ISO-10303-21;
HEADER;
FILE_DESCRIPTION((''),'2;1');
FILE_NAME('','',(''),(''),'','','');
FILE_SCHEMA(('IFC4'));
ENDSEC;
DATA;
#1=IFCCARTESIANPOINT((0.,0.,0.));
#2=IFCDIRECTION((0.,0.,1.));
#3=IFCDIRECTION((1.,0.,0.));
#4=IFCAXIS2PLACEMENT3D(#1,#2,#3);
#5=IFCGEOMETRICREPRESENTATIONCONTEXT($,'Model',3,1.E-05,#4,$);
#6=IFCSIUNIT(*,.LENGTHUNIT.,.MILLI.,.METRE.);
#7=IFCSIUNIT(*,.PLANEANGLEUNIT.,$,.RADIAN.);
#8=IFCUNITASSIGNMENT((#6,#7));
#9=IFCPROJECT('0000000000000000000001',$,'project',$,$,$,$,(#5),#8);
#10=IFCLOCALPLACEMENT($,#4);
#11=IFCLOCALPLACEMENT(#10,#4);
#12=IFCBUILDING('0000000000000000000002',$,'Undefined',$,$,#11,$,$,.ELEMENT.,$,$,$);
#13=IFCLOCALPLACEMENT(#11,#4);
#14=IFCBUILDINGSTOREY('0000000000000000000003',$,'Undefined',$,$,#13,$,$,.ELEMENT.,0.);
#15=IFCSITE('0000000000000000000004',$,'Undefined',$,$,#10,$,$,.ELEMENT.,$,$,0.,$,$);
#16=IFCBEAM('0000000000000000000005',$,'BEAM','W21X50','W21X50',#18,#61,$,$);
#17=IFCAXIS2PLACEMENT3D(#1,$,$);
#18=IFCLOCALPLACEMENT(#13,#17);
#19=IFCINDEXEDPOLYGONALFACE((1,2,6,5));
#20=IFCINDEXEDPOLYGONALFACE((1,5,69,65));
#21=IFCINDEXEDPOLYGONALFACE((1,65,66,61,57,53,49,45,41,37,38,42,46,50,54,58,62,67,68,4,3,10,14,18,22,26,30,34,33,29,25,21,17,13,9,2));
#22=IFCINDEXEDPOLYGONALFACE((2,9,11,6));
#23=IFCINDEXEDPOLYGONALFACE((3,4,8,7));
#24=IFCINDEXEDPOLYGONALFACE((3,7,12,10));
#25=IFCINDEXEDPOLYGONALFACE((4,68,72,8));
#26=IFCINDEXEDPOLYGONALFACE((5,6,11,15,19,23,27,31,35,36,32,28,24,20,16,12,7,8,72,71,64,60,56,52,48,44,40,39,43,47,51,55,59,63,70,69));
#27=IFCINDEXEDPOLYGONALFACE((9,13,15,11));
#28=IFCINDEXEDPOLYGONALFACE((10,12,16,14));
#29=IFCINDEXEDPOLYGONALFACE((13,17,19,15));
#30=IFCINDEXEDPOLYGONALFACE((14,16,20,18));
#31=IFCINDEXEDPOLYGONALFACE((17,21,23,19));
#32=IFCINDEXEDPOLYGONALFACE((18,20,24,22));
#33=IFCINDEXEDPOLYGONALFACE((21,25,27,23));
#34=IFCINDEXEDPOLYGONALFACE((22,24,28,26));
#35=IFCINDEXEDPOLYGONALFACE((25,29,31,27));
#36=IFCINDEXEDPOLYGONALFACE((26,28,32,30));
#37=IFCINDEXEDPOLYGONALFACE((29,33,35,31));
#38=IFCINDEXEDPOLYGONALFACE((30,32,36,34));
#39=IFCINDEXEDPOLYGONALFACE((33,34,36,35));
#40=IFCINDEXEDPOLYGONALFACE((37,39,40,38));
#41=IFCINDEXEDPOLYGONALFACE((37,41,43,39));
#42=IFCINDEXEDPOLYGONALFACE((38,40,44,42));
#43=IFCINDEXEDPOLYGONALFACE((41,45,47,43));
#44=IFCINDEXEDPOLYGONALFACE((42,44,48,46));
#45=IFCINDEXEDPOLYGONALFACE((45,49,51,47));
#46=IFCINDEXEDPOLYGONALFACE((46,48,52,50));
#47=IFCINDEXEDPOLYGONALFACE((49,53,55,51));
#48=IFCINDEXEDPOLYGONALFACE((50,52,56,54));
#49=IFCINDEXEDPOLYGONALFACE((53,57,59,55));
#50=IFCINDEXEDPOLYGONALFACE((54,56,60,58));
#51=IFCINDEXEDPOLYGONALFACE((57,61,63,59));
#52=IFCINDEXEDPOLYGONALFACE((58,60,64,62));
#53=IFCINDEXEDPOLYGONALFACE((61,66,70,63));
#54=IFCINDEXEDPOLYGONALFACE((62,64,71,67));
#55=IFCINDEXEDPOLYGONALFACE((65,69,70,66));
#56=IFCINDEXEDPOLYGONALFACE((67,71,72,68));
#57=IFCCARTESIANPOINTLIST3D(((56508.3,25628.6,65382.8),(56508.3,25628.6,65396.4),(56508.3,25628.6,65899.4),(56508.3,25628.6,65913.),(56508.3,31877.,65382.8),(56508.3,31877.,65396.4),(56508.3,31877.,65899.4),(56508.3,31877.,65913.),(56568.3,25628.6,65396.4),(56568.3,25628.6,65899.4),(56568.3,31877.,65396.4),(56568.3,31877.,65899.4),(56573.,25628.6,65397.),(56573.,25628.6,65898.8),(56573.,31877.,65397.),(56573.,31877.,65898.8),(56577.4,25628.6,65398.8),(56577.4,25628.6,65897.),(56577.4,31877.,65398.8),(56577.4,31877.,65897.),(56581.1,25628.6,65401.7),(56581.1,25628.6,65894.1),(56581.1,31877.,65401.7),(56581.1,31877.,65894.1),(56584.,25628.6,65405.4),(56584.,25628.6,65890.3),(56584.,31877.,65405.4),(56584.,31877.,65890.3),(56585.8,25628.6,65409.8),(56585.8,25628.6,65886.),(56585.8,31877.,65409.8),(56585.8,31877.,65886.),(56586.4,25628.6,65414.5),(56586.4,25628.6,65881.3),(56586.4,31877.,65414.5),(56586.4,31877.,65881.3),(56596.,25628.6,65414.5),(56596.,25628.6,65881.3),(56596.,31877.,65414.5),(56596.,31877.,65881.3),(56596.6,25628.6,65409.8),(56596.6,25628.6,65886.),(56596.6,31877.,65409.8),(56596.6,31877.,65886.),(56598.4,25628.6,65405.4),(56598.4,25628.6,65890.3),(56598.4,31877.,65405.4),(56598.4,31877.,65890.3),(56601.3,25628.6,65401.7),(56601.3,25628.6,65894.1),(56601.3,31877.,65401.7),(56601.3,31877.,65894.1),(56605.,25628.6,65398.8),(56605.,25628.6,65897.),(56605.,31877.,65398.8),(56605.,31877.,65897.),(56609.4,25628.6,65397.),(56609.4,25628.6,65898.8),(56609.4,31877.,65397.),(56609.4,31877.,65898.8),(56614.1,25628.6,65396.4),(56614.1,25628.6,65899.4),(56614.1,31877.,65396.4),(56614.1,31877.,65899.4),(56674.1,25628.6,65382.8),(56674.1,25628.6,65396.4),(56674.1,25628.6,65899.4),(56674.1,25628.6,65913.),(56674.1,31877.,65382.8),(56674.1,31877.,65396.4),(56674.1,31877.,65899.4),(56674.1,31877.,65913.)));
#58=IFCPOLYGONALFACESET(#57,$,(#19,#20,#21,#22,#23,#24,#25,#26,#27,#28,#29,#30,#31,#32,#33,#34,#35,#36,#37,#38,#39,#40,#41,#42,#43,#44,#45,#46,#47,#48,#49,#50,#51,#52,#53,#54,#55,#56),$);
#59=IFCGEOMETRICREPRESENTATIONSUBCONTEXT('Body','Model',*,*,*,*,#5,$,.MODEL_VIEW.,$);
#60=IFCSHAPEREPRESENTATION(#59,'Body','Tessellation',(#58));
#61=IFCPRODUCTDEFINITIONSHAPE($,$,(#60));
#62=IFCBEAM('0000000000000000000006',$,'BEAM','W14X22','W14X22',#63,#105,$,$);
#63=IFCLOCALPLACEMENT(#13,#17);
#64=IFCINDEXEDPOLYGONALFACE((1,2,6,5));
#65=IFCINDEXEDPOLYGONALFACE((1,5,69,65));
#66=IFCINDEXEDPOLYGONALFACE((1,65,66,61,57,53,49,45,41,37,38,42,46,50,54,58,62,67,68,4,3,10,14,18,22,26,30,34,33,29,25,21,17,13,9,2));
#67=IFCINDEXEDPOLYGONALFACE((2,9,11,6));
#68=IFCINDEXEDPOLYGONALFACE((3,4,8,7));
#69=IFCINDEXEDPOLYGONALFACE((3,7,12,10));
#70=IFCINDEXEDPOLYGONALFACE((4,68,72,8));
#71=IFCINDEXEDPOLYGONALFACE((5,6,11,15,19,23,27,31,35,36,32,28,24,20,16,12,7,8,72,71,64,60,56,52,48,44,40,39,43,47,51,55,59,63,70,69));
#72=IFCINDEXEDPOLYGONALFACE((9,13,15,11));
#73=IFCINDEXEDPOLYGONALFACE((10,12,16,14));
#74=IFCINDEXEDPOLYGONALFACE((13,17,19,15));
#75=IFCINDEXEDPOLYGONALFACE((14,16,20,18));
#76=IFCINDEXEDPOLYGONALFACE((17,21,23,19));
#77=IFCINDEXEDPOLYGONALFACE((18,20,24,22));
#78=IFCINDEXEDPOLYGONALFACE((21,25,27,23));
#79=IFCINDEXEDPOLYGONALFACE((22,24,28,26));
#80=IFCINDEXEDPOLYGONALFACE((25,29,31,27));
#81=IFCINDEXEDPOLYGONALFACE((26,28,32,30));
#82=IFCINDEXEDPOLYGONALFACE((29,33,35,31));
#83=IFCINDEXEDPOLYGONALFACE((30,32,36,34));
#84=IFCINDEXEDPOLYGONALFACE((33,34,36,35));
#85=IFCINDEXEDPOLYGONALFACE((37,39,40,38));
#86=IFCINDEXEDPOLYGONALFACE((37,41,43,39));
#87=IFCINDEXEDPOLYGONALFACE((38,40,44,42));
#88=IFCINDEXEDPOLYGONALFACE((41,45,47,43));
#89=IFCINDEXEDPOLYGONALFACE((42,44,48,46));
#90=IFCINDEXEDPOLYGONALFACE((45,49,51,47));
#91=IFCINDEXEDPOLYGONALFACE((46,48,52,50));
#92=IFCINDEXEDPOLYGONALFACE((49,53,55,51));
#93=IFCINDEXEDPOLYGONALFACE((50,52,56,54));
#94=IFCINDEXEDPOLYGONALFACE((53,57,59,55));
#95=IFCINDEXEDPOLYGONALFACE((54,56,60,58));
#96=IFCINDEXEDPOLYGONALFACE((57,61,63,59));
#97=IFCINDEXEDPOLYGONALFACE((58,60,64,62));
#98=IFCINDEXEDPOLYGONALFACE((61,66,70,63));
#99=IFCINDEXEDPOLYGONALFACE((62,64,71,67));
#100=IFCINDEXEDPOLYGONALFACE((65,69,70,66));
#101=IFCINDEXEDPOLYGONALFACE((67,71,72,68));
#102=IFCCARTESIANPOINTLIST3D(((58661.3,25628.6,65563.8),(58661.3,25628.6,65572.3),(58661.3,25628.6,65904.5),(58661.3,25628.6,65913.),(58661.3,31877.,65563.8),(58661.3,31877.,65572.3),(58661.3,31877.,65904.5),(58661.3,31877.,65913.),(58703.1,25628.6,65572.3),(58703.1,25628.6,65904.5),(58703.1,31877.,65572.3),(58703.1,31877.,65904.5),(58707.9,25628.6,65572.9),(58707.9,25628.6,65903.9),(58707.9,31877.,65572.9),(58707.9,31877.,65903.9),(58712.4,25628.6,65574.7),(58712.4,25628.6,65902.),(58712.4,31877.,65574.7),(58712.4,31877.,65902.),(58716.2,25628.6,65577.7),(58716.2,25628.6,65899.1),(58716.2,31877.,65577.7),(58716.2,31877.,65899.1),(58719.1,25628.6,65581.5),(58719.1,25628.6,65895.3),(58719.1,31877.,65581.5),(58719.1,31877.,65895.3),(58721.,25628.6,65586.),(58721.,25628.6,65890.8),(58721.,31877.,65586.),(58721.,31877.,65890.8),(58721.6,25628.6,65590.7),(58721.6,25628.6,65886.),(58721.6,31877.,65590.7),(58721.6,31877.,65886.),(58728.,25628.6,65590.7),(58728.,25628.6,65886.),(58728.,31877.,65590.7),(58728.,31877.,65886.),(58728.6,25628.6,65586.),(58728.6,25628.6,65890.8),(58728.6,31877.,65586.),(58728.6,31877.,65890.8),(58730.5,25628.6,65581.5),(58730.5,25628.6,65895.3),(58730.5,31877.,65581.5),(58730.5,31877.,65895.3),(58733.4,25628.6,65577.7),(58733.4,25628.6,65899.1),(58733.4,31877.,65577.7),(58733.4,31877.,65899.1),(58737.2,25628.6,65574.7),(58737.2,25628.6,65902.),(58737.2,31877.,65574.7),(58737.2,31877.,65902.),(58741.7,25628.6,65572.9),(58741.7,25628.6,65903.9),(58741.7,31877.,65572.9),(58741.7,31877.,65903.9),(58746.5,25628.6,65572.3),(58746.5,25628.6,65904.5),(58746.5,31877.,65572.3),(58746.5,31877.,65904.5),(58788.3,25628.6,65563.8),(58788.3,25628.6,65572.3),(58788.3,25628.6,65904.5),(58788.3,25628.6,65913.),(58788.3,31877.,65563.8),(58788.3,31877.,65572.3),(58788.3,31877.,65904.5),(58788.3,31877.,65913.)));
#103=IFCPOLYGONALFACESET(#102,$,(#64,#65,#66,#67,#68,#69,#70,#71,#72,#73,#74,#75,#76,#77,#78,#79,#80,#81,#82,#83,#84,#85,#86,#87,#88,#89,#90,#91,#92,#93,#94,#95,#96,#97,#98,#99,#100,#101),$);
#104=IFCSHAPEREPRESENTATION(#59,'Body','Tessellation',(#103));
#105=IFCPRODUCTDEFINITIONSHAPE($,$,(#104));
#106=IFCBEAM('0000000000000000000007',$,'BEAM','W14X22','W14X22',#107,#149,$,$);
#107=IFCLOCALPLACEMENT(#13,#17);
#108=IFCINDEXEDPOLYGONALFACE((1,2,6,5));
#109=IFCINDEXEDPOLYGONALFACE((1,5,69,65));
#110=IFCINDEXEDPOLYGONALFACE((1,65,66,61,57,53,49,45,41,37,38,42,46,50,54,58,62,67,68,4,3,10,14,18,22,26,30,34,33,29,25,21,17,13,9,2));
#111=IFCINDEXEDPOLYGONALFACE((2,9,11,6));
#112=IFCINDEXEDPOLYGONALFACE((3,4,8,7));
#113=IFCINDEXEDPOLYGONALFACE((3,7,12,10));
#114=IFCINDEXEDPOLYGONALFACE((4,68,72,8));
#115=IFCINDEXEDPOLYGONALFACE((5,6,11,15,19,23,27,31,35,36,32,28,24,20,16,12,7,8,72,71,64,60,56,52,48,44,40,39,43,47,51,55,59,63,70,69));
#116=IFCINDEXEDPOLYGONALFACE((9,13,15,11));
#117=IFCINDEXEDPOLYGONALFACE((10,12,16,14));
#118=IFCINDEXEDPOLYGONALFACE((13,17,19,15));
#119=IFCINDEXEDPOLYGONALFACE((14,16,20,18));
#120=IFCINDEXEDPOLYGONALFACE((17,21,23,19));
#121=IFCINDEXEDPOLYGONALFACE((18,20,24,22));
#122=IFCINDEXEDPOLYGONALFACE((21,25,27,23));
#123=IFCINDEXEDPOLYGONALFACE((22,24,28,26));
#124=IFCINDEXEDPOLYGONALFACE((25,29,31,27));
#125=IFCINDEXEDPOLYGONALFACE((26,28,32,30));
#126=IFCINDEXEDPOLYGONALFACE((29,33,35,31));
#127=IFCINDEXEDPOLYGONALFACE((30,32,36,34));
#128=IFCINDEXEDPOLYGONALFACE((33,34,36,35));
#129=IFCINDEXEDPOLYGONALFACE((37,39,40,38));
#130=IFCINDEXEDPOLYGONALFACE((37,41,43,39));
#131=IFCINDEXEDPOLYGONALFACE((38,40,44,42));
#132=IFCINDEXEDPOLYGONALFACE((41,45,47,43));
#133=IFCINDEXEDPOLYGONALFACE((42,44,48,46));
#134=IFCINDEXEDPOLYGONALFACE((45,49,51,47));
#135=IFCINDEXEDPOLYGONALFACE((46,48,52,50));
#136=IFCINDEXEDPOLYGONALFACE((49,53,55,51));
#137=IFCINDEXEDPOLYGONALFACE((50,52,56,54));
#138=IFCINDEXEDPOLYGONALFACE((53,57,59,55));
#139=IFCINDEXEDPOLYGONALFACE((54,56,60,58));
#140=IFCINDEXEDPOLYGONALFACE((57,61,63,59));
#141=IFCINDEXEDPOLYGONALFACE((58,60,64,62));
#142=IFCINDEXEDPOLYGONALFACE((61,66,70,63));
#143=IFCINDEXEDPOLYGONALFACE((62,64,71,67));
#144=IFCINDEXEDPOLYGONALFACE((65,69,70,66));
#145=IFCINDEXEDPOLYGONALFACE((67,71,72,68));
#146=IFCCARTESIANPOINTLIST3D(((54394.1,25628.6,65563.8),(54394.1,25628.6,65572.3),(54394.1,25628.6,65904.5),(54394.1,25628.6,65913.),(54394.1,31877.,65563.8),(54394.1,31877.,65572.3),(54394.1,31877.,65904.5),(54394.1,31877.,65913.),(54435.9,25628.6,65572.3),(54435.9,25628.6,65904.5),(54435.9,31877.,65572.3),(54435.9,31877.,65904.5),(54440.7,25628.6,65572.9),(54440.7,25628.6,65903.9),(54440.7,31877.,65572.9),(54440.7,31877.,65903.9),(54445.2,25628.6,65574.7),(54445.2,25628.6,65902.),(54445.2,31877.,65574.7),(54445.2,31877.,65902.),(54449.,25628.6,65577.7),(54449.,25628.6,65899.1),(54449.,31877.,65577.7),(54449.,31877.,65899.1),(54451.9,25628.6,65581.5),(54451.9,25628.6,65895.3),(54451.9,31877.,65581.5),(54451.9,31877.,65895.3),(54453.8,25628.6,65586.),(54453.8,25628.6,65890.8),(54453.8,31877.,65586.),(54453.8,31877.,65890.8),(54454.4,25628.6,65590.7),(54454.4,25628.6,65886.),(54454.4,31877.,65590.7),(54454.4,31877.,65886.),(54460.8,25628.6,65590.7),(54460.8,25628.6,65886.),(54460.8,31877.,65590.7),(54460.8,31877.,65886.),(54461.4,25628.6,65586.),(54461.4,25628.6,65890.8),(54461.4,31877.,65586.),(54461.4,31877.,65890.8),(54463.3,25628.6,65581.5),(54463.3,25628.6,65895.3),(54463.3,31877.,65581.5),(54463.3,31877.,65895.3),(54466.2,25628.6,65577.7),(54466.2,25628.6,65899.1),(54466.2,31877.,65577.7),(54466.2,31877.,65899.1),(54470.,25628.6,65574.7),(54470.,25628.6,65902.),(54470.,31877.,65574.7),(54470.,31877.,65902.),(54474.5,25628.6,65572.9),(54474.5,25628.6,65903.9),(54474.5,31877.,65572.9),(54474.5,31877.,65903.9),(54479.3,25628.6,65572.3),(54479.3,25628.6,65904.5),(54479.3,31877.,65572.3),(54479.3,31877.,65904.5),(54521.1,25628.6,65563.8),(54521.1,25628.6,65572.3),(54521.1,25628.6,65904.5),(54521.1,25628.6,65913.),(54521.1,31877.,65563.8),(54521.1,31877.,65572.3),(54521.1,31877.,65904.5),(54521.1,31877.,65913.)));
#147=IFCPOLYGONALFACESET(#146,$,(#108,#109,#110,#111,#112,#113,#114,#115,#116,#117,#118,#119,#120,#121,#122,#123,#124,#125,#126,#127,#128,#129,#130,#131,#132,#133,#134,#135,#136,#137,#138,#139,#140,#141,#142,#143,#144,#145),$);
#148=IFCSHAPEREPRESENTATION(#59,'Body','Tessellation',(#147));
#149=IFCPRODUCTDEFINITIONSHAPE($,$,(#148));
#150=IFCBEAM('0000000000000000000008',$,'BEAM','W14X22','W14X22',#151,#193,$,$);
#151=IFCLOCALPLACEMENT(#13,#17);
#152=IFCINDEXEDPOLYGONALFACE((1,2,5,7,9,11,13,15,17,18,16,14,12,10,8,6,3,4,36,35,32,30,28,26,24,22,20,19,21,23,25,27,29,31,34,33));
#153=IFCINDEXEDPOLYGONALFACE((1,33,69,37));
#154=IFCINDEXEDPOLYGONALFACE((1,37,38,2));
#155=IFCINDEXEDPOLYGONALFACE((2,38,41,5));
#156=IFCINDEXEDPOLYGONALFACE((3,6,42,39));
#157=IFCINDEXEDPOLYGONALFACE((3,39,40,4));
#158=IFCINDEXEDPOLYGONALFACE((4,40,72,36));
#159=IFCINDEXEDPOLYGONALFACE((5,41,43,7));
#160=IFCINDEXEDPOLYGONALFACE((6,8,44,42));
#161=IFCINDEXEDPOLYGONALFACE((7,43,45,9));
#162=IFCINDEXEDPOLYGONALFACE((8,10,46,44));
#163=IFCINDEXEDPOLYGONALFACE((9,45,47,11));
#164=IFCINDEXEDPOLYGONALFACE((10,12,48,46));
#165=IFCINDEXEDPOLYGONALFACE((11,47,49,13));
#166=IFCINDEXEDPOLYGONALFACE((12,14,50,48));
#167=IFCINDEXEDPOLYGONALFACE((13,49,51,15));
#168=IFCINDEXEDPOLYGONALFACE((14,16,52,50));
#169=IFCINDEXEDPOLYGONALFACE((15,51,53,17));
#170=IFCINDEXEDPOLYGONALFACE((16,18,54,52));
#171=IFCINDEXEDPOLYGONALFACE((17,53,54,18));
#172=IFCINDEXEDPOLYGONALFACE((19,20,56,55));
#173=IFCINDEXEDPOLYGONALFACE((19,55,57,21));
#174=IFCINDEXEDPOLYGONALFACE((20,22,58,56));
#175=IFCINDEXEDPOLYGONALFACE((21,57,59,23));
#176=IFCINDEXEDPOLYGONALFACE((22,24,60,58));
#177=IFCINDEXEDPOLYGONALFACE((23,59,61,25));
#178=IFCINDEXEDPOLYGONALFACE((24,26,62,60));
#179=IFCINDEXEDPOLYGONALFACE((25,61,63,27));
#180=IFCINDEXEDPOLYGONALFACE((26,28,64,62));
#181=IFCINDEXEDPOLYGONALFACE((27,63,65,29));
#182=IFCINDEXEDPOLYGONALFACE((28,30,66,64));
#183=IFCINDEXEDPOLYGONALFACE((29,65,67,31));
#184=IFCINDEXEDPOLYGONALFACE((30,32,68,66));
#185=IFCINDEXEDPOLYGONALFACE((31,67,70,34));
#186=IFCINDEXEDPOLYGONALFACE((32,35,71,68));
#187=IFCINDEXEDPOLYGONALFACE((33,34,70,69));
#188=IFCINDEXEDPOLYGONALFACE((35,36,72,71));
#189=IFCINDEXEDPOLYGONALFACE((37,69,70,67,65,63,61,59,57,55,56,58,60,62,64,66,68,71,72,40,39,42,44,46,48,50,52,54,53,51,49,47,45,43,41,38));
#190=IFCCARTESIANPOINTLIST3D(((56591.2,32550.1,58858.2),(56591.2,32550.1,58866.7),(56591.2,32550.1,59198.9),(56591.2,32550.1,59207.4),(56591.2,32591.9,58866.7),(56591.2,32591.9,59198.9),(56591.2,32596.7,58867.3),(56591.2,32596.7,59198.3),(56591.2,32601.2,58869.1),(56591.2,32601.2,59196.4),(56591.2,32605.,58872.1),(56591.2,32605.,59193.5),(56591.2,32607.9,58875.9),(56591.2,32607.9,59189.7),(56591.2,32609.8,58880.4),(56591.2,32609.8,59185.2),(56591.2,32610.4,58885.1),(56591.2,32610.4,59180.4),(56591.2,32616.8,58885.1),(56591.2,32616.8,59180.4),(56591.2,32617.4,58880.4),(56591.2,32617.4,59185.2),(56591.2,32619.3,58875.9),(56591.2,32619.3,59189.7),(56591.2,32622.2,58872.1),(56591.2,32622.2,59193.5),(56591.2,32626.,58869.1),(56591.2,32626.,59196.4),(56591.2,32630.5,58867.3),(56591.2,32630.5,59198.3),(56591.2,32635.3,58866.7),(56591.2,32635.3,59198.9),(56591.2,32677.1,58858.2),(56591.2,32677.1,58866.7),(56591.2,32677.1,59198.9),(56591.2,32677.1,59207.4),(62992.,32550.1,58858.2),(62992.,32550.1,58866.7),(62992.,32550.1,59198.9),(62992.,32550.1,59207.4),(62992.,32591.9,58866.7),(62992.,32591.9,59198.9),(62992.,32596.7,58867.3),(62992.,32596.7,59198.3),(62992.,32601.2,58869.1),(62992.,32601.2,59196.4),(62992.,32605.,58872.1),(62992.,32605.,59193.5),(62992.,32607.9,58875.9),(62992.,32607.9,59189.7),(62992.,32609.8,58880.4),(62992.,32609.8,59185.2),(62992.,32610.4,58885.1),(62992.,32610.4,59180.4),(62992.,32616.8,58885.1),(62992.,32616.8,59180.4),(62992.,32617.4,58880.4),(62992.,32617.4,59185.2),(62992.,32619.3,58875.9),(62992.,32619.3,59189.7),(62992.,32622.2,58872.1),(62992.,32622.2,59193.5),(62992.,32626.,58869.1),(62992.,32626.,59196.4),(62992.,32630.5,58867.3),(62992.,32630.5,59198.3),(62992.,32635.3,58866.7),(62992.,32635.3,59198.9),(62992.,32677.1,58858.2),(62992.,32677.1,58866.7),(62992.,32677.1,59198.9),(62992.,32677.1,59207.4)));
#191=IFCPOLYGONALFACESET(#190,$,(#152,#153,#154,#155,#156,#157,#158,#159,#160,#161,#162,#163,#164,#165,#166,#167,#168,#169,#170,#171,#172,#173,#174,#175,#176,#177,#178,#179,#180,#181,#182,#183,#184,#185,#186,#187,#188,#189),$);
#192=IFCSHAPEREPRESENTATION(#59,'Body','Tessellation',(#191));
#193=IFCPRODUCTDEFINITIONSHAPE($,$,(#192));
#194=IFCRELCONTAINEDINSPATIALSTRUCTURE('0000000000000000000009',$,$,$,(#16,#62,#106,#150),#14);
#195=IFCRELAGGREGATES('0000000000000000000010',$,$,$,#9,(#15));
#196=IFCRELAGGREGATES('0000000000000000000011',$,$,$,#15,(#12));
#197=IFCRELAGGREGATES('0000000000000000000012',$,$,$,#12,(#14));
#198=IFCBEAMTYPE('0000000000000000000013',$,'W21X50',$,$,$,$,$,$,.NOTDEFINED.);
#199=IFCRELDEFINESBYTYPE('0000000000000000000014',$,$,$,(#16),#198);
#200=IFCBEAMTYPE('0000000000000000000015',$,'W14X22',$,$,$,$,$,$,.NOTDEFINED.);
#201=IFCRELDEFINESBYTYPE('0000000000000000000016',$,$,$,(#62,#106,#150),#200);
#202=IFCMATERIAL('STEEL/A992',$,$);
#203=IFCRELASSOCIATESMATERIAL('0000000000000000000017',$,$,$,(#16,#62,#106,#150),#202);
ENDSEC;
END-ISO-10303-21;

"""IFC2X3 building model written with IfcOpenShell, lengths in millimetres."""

from ifc_helpers import new_model, si_unit, frame, origin_with_axes, origin_2d_with_axis, place, context, subcontext, project, spatial, i_section, extrude, material, type_object, element, save


model = new_model("IFC2X3")

# Units and contexts
model_context = context("Model", 3, precision=1e-05, world=origin_with_axes())
body_context = subcontext(model_context, "Body", "Model", "MODEL_VIEW")
ifc_project = project(units=[si_unit("LENGTHUNIT", "METRE", prefix="MILLI"), si_unit("PLANEANGLEUNIT", "RADIAN")], contexts=[model_context])

# Site, building, storey
site_placement = place(None, origin_with_axes())
site = spatial("IfcSite", under=ifc_project, at=site_placement, Name="Undefined", CompositionType="ELEMENT", RefElevation=0.0)
building_placement = place(site_placement, origin_with_axes())
building = spatial("IfcBuilding", under=site, at=building_placement, Name="Undefined", CompositionType="ELEMENT")
storey_placement = place(building_placement, origin_with_axes())
storey = spatial("IfcBuildingStorey", under=building, at=storey_placement, Name="Undefined", CompositionType="ELEMENT", Elevation=0.0)

# Beams
ifc_material_1 = material(Name="STEEL/A992")
beam_type_1 = type_object("IfcBeamType", Name="W21X50", PredefinedType="NOTDEFINED")
beam_1_placement = place(storey_placement, frame((56591.2, 25628.6, 65647.9), z_axis=(0.0, 0.0, 1.0), x_axis=(0.0, 1.0, 0.0)))
element("IfcBeam", 1, at=beam_1_placement, inside=storey, type_object=beam_type_1, material=ifc_material_1, Name="BEAM", Description="W21X50", ObjectType="W21X50", context=body_context, shape_type="SweptSolid", body=[
    extrude(i_section(OverallWidth=165.9, OverallDepth=530.2, WebThickness=9.5, FlangeThickness=13.6, FilletRadius=18.2, at=origin_2d_with_axis()), frame((6248.4, 0.0, 0.0), z_axis=(-1.0, 0.0, 0.0), x_axis=(0.0, -1.0, 0.0)), (0.0, 0.0, 1.0), 6248.4),
])
beam_type_2 = type_object("IfcBeamType", Name="W14X22", PredefinedType="NOTDEFINED")
for number, where, z_axis, x_axis, name in (
    (2, (58724.8, 25628.6, 65738.4), (0.0, 0.0, 1.0), (0.0, 1.0, 0.0), "BEAM"),
    (3, (54457.6, 25628.6, 65738.4), (0.0, 0.0, 1.0), (0.0, 1.0, 0.0), "BEAM"),
):
    element("IfcBeam", number, at=place(storey_placement, frame(where, z_axis=z_axis, x_axis=x_axis)), inside=storey, type_object=beam_type_2, material=ifc_material_1, Name=name, Description="W14X22", ObjectType="W14X22", context=body_context, shape_type="SweptSolid", body=[
        extrude(i_section(OverallWidth=127.0, OverallDepth=349.2, WebThickness=6.3, FlangeThickness=8.5, FilletRadius=18.5, at=origin_2d_with_axis()), frame((6248.4, 0.0, 0.0), z_axis=(-1.0, 0.0, 0.0), x_axis=(0.0, -1.0, 0.0)), (0.0, 0.0, 1.0), 6248.4),
    ])
beam_2_placement = place(storey_placement, frame((56591.2, 32613.6, 59032.8), z_axis=(0.0, 0.0, 1.0), x_axis=(1.0, 0.0, 0.0)))
element("IfcBeam", 4, at=beam_2_placement, inside=storey, type_object=beam_type_2, material=ifc_material_1, Name="BEAM", Description="W14X22", ObjectType="W14X22", context=body_context, shape_type="SweptSolid", body=[
    extrude(i_section(OverallWidth=127.0, OverallDepth=349.2, WebThickness=6.3, FlangeThickness=8.5, FilletRadius=18.5, at=origin_2d_with_axis()), frame((6400.8, 0.0, 0.0), z_axis=(-1.0, 0.0, 0.0), x_axis=(0.0, -1.0, 0.0)), (0.0, 0.0, 1.0), 6400.8),
])

save(model, "model.ifc")
